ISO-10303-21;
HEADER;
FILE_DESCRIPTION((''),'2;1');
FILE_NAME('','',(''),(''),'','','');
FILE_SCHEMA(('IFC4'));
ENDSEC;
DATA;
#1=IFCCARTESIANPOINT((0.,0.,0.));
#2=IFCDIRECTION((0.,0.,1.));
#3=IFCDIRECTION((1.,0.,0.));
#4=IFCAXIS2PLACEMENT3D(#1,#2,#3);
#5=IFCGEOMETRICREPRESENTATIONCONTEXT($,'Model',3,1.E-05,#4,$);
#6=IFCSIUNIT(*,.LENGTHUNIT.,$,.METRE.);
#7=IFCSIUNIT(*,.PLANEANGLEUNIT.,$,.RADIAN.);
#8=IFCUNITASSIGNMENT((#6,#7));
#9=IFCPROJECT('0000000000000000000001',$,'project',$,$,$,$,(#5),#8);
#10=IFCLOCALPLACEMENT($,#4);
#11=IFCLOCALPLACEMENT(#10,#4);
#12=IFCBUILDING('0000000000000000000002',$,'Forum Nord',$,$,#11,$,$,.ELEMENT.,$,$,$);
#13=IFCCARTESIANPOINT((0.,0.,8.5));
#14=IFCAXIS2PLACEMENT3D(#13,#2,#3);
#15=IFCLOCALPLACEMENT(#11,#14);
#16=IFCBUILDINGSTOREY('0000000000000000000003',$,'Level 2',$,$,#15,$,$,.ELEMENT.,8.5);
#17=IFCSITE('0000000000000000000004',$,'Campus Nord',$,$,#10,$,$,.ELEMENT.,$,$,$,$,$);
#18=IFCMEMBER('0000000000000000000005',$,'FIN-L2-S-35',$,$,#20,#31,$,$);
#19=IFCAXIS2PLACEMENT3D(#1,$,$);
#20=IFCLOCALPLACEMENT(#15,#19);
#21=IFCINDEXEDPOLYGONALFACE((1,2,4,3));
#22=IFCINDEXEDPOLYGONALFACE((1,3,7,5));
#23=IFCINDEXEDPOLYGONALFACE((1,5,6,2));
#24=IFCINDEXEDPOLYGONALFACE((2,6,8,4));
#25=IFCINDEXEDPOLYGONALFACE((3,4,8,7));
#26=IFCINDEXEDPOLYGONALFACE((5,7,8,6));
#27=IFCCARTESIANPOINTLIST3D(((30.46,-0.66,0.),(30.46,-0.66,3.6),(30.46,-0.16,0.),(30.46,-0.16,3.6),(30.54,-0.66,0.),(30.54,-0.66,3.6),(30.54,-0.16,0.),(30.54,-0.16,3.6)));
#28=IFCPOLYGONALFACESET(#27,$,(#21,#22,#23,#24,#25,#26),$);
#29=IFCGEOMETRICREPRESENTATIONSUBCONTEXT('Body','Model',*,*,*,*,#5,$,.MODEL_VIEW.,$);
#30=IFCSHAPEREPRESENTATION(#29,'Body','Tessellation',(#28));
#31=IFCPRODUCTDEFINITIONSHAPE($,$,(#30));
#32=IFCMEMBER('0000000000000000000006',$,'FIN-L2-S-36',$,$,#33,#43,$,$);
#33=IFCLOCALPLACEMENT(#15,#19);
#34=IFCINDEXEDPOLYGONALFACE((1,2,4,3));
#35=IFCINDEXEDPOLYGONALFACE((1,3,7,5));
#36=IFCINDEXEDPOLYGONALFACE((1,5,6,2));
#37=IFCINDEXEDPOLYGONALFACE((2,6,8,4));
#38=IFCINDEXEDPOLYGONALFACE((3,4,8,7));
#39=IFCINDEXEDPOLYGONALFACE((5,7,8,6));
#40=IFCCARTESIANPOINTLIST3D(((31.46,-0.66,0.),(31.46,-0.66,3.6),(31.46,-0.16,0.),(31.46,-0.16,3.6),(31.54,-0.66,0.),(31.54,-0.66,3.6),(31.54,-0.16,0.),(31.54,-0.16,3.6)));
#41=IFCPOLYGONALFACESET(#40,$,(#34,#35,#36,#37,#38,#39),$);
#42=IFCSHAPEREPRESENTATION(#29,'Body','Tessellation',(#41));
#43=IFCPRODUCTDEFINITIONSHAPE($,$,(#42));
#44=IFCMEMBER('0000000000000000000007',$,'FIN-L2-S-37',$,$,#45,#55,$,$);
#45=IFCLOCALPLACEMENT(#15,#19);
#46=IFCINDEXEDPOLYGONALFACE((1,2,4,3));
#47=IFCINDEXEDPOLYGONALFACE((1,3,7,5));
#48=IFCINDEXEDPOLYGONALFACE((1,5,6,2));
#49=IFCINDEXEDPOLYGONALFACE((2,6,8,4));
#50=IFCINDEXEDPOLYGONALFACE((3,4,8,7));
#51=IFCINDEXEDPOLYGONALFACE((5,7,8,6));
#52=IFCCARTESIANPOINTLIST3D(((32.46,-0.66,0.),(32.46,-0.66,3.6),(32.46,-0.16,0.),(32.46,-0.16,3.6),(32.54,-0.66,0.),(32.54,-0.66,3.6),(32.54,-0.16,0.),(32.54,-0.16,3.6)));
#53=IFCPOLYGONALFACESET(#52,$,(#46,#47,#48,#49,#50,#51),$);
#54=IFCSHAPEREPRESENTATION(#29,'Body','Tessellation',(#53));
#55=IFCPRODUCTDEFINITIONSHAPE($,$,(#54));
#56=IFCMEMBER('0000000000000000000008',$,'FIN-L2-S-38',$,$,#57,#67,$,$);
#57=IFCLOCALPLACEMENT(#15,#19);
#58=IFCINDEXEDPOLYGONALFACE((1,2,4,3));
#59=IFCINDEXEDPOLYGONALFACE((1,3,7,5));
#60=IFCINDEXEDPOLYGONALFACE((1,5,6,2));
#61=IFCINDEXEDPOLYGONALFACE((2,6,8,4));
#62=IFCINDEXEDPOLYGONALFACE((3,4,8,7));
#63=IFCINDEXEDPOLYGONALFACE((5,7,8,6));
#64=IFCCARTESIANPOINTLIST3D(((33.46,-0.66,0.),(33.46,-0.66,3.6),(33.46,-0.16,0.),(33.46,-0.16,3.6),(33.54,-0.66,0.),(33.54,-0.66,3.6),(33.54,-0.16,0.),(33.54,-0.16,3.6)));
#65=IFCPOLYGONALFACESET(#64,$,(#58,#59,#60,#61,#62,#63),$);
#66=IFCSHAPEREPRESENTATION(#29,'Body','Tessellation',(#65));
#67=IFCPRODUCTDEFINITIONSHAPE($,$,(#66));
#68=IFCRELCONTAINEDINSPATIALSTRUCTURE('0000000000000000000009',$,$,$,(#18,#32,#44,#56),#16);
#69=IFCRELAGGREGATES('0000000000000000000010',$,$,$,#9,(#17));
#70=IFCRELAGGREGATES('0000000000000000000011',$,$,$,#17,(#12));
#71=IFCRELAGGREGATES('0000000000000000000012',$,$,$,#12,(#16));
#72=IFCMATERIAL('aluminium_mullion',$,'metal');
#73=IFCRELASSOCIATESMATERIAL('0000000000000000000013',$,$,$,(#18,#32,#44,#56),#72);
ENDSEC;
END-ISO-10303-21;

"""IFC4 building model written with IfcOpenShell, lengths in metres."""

from ifc_helpers import new_model, si_unit, frame, origin_with_axes, place, context, subcontext, project, spatial, polyline, outline, extrude, material, element, save


model = new_model("IFC4")

# Units and contexts
model_context = context("Model", 3, precision=1e-05, world=origin_with_axes())
body_context = subcontext(model_context, "Body", "Model", "MODEL_VIEW")
ifc_project = project(units=[si_unit("LENGTHUNIT", "METRE"), si_unit("PLANEANGLEUNIT", "RADIAN")], contexts=[model_context])

# Site, building, storey
site_placement = place(None, origin_with_axes())
site = spatial("IfcSite", under=ifc_project, at=site_placement, Name="Campus Nord", CompositionType="ELEMENT")
building_placement = place(site_placement, origin_with_axes())
building = spatial("IfcBuilding", under=site, at=building_placement, Name="Forum Nord", CompositionType="ELEMENT")
storey_placement = place(building_placement, frame((0.0, 0.0, 8.5), z_axis=(0.0, 0.0, 1.0), x_axis=(1.0, 0.0, 0.0)))
storey = spatial("IfcBuildingStorey", under=building, at=storey_placement, Name="Level 2", CompositionType="ELEMENT", Elevation=8.5)

# Members
ifc_material = material(Name="aluminium_mullion", Category="metal")
member_1_placement = place(storey_placement, origin_with_axes())
element("IfcMember", 1, at=member_1_placement, inside=storey, material=ifc_material, Name="FIN-L2-S-35", context=body_context, shape_type="SweptSolid", body=[
    extrude(outline(polyline([(30.46, -0.66), (30.54, -0.66), (30.54, -0.16), (30.46, -0.16), (30.46, -0.66)])), origin_with_axes(), (0.0, 0.0, 1.0), 3.6),
])
member_2_placement = place(storey_placement, origin_with_axes())
element("IfcMember", 2, at=member_2_placement, inside=storey, material=ifc_material, Name="FIN-L2-S-36", context=body_context, shape_type="SweptSolid", body=[
    extrude(outline(polyline([(31.46, -0.66), (31.54, -0.66), (31.54, -0.16), (31.46, -0.16), (31.46, -0.66)])), origin_with_axes(), (0.0, 0.0, 1.0), 3.6),
])
member_3_placement = place(storey_placement, origin_with_axes())
element("IfcMember", 3, at=member_3_placement, inside=storey, material=ifc_material, Name="FIN-L2-S-37", context=body_context, shape_type="SweptSolid", body=[
    extrude(outline(polyline([(32.46, -0.66), (32.54, -0.66), (32.54, -0.16), (32.46, -0.16), (32.46, -0.66)])), origin_with_axes(), (0.0, 0.0, 1.0), 3.6),
])
member_4_placement = place(storey_placement, origin_with_axes())
element("IfcMember", 4, at=member_4_placement, inside=storey, material=ifc_material, Name="FIN-L2-S-38", context=body_context, shape_type="SweptSolid", body=[
    extrude(outline(polyline([(33.46, -0.66), (33.54, -0.66), (33.54, -0.16), (33.46, -0.16), (33.46, -0.66)])), origin_with_axes(), (0.0, 0.0, 1.0), 3.6),
])

save(model, "model.ifc")
